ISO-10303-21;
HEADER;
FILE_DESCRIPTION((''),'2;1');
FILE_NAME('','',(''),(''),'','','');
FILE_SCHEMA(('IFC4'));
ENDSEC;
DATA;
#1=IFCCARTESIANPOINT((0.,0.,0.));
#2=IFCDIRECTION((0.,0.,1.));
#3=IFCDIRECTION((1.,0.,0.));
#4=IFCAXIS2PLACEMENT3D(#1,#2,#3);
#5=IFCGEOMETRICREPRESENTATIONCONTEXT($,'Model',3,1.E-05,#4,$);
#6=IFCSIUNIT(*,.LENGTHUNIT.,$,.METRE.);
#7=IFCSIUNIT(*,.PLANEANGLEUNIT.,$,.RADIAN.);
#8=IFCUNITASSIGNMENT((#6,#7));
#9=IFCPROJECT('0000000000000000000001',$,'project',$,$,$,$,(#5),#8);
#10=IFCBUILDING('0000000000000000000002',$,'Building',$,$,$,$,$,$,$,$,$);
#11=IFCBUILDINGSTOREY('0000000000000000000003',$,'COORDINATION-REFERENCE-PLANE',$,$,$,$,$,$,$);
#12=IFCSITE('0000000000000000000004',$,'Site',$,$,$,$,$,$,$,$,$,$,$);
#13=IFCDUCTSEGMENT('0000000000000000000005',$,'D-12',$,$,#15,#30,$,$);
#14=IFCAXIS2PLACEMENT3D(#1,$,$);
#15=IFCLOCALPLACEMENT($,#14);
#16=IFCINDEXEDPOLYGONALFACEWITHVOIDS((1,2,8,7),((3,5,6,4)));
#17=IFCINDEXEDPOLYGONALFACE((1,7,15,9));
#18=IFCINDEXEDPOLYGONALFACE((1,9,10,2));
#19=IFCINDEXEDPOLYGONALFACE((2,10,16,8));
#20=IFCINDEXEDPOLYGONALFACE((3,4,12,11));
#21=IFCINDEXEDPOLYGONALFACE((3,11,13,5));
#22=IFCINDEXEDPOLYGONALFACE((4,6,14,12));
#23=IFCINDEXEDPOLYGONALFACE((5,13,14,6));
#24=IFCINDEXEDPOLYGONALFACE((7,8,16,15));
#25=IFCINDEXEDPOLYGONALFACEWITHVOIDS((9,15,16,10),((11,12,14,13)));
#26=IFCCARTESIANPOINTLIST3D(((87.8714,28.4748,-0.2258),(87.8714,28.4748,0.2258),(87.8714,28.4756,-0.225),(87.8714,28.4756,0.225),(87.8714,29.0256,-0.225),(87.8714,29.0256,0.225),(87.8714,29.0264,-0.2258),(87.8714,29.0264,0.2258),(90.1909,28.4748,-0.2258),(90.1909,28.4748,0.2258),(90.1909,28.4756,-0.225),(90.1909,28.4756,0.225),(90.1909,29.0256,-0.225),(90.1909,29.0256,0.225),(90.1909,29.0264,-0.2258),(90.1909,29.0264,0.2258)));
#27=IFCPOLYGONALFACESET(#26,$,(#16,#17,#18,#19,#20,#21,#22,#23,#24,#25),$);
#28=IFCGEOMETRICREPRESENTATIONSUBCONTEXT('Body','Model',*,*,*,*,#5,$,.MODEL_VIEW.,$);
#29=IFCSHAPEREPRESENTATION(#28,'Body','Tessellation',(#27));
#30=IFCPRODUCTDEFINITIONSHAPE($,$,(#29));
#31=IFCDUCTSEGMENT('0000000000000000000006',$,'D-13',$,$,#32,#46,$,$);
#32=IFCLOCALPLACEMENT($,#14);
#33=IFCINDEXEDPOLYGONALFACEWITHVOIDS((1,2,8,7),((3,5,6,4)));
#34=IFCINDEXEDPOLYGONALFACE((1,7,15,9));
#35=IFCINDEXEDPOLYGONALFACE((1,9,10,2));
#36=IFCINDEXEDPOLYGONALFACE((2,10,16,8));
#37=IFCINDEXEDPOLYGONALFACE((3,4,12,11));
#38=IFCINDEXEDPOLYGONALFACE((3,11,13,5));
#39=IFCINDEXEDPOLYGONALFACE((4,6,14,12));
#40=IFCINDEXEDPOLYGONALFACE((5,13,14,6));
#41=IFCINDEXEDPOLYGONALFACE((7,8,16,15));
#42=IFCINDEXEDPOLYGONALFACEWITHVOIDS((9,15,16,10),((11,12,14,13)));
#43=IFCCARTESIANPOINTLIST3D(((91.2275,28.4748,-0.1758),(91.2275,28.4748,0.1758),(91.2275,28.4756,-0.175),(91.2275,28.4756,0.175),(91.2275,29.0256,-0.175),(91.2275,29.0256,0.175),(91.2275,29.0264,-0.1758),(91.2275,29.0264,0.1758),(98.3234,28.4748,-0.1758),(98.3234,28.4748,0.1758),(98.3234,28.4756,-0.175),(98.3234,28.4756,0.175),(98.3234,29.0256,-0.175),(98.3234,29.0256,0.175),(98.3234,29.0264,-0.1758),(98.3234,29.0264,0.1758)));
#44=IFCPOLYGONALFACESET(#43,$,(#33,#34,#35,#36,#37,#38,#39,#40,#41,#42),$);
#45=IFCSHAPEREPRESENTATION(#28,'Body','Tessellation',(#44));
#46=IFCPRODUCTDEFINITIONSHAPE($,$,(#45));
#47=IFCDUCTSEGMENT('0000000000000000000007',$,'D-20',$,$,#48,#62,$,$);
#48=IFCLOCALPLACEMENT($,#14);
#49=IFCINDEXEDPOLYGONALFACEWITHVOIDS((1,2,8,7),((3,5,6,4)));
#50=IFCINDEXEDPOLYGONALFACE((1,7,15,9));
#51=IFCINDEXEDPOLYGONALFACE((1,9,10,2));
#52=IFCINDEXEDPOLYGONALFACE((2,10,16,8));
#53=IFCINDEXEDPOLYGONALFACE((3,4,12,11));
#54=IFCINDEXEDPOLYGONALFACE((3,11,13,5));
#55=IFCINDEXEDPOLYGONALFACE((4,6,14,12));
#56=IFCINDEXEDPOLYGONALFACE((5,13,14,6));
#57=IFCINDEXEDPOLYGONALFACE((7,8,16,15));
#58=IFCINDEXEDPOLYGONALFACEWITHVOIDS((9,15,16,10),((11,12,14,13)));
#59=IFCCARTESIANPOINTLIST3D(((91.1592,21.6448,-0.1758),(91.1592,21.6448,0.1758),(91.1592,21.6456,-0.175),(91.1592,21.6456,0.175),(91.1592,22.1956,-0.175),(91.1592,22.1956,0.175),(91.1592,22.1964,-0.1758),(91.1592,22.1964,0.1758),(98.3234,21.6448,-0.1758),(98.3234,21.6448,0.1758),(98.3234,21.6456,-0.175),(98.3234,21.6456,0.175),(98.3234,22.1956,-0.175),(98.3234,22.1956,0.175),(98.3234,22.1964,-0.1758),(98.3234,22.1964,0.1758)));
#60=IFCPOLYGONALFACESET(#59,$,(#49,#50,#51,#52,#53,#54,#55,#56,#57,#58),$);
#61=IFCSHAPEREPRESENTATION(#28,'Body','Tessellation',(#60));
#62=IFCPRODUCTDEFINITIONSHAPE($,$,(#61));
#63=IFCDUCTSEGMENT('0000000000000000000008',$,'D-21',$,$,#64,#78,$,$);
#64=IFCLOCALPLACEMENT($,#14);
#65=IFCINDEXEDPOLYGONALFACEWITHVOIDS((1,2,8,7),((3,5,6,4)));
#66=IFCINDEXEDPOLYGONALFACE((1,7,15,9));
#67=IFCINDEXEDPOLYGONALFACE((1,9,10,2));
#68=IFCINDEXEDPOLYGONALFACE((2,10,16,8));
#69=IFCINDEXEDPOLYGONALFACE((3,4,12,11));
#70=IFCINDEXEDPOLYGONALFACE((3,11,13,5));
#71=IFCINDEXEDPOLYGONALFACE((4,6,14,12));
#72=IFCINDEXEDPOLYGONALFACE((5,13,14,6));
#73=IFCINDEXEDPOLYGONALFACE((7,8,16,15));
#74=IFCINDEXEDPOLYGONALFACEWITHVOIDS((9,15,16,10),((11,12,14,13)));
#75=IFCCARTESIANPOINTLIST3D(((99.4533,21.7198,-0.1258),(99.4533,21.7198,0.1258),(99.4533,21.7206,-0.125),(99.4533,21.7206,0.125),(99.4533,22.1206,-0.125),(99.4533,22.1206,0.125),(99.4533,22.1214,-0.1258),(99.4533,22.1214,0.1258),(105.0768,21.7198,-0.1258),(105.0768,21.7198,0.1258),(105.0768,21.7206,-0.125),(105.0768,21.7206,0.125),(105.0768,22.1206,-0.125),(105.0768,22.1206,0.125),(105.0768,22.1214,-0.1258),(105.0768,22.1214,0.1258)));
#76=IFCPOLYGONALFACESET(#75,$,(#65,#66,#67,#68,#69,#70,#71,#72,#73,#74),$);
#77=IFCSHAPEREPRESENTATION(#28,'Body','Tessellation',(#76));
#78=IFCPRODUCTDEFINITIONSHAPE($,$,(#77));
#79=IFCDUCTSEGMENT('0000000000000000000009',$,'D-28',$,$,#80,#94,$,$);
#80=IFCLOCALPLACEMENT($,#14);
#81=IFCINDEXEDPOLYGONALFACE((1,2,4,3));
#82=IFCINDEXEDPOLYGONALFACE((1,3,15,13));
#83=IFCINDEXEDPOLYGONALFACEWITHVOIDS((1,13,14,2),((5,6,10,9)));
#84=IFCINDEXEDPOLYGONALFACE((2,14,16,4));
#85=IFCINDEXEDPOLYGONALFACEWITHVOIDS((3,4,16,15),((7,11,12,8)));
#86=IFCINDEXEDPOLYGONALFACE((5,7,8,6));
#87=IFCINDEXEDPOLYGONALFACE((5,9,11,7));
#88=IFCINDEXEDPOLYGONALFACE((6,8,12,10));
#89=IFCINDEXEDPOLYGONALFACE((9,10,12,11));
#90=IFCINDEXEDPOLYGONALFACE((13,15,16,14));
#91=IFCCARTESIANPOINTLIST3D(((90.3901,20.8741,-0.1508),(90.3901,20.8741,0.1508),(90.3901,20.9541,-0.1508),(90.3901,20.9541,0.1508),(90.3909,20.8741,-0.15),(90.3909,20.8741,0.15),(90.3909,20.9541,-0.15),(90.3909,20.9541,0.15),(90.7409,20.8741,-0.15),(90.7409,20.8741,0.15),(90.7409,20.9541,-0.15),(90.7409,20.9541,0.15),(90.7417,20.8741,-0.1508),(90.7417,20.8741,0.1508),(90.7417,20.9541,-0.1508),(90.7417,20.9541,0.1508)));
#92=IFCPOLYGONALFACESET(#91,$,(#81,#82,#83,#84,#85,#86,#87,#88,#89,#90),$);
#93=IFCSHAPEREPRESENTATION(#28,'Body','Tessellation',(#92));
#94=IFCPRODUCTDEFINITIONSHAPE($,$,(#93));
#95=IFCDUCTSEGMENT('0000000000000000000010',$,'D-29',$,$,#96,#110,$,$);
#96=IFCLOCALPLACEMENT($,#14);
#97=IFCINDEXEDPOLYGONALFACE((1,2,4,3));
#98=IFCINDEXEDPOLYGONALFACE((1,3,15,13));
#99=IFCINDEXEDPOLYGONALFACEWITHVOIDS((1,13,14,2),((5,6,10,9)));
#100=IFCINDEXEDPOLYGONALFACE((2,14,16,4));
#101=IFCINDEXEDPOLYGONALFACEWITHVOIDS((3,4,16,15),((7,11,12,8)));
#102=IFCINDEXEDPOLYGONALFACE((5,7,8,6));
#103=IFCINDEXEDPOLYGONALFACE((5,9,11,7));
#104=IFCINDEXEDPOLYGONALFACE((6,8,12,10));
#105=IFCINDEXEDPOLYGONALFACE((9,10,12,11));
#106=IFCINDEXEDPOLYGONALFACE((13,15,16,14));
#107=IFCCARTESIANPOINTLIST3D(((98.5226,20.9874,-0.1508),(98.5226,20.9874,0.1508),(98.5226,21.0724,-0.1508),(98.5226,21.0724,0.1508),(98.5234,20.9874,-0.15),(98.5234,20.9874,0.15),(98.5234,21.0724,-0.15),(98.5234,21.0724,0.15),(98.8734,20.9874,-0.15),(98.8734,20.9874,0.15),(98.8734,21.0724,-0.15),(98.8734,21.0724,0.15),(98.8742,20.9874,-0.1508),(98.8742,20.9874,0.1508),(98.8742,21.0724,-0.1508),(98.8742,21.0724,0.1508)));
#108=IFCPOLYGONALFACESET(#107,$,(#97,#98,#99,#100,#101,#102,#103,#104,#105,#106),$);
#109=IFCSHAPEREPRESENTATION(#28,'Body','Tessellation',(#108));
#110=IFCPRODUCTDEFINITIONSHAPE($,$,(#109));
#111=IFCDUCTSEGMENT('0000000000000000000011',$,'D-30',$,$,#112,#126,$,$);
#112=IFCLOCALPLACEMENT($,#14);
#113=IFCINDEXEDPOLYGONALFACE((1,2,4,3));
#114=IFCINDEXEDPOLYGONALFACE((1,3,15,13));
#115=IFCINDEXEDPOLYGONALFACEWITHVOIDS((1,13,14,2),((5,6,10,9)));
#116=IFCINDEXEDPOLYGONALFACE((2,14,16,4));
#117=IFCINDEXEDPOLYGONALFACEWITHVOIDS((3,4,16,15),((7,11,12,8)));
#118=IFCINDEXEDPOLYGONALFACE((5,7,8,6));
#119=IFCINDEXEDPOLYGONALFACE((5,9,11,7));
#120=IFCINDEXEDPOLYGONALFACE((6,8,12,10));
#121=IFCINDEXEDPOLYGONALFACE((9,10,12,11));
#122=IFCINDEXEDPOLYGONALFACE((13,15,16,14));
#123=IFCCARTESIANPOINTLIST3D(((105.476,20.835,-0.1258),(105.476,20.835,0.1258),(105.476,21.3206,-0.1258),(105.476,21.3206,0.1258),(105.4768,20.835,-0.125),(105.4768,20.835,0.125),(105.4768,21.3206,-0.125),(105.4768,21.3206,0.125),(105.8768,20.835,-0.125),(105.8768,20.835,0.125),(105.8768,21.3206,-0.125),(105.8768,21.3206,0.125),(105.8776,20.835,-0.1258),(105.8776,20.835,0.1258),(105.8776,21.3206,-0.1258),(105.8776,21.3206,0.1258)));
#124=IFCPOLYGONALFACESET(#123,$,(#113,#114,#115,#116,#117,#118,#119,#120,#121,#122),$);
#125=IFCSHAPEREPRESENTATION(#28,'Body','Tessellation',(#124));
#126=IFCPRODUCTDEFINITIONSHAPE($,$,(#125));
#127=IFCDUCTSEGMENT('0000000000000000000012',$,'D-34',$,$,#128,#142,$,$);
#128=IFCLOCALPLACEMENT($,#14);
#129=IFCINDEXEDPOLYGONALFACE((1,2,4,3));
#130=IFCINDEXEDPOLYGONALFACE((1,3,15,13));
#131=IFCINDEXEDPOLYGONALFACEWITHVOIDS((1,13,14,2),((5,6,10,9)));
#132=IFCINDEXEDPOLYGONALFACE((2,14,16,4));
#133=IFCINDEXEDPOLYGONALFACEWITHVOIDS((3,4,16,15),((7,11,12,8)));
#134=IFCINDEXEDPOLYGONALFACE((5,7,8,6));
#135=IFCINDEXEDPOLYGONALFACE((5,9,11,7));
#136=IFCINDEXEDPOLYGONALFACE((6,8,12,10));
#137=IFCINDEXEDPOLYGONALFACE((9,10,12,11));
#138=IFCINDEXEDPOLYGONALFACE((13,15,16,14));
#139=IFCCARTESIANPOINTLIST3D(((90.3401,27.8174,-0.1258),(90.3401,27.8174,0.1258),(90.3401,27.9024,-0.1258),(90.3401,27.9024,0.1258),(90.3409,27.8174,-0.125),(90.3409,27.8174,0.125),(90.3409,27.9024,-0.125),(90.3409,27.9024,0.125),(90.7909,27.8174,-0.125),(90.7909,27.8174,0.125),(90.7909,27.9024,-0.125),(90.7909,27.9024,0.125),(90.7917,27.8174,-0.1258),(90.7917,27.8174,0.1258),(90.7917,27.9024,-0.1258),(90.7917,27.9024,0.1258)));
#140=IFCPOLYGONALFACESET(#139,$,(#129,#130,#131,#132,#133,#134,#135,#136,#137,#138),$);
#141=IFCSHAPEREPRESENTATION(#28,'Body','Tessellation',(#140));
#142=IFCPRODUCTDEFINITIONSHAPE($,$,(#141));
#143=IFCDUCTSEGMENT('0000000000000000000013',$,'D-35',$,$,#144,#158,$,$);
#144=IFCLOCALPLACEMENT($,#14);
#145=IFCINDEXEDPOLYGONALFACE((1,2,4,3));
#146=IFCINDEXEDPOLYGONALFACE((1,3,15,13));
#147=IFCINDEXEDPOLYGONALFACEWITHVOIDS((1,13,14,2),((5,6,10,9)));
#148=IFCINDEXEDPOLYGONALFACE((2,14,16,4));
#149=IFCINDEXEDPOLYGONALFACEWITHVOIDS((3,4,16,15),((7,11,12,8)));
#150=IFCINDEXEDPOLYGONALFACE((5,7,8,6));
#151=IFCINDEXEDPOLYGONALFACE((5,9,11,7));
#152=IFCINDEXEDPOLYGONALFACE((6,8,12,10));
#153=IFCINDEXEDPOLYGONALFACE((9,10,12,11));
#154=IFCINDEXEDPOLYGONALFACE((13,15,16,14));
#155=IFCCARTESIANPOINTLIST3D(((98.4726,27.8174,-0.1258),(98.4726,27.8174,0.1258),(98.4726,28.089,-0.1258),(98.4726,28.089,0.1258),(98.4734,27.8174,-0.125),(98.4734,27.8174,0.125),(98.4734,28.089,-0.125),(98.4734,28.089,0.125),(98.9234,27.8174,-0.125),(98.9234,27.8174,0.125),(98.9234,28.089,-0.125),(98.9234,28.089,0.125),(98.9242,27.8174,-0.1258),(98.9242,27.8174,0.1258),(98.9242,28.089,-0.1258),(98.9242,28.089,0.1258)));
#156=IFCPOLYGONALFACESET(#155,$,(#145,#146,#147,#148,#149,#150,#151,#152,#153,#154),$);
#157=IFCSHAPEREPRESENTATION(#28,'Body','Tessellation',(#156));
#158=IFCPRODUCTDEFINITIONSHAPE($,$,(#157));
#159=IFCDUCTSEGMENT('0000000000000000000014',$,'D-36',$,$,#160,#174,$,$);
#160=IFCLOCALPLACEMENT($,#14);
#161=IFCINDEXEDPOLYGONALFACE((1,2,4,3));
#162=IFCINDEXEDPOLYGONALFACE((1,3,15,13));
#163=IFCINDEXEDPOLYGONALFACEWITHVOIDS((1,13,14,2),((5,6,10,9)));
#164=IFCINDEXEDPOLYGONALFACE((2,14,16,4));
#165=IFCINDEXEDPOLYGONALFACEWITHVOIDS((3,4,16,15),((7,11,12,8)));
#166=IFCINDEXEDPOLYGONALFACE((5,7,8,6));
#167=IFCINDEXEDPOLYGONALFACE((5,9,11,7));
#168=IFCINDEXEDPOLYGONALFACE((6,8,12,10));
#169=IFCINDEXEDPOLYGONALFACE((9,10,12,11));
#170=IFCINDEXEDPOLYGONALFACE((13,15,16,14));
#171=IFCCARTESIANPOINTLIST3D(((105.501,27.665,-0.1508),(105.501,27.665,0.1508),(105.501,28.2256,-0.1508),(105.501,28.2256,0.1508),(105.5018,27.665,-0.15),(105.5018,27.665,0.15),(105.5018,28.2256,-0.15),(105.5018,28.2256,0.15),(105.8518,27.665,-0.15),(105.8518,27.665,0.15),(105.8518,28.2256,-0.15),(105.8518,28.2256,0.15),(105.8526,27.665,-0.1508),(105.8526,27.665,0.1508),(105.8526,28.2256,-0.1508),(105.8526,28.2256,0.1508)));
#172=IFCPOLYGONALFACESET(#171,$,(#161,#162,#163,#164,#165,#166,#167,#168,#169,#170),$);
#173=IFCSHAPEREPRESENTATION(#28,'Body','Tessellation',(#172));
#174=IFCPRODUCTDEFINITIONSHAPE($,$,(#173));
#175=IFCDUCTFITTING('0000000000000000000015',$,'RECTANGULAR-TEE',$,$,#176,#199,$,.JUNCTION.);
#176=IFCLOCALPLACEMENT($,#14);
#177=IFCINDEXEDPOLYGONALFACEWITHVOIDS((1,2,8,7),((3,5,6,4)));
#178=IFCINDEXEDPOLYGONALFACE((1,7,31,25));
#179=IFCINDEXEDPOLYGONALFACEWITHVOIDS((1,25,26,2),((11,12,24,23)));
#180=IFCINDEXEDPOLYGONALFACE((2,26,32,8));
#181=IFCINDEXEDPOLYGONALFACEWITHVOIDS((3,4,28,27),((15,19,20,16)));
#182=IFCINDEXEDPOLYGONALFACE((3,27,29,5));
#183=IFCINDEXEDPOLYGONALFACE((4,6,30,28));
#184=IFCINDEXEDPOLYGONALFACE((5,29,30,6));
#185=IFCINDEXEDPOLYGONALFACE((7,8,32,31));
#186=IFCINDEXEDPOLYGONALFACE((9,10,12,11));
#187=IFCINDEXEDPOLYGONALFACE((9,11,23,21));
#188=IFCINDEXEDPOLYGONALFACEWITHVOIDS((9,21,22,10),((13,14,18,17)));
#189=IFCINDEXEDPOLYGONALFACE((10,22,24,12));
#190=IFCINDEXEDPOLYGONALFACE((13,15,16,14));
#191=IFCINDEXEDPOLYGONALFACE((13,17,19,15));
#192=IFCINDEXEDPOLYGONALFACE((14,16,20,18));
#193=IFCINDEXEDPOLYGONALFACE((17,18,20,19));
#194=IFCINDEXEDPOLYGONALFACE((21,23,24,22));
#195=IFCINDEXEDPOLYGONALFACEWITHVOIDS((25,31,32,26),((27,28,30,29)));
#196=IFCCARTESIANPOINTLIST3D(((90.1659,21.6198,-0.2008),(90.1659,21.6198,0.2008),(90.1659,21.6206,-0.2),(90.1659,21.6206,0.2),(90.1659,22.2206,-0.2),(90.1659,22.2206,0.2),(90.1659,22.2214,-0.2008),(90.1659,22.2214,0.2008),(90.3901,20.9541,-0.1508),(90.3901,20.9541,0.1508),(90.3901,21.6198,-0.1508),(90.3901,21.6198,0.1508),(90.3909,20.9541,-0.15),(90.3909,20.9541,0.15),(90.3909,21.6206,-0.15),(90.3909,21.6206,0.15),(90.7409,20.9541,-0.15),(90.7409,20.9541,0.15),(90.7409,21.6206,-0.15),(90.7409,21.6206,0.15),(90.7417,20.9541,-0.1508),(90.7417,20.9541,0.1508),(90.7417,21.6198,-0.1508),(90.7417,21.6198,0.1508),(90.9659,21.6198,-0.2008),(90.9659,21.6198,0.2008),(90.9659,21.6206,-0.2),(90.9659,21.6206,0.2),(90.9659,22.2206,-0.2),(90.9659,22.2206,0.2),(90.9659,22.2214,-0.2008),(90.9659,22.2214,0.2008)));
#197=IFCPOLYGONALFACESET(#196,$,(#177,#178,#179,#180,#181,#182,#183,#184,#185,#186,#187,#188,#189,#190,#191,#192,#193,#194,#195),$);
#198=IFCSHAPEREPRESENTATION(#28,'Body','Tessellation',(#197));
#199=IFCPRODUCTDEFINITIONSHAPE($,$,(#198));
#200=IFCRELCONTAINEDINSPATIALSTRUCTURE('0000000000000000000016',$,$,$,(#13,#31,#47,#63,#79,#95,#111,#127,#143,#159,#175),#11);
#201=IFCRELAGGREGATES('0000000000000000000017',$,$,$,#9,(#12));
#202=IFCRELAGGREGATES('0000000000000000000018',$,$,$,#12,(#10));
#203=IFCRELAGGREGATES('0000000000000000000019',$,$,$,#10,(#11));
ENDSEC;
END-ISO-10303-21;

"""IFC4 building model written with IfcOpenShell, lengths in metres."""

from ifc_helpers import new_model, si_unit, frame, origin, origin_with_axes, place, context, subcontext, project, spatial, rectangle, hollow_rectangle, extrude, boolean, element, save


model = new_model("IFC4")

# Units and contexts
model_context = context("Model", 3, precision=1e-05, world=origin_with_axes())
body_context_1 = subcontext(model_context, "Body", "Model", "MODEL_VIEW")
ifc_project = project(units=[si_unit("LENGTHUNIT", "METRE"), si_unit("PLANEANGLEUNIT", "RADIAN")], contexts=[model_context])

# Site, building, storey
site = spatial("IfcSite", under=ifc_project, Name="Site")
building = spatial("IfcBuilding", under=site, Name="Building")
storey = spatial("IfcBuildingStorey", under=building, Name="COORDINATION-REFERENCE-PLANE")

# Duct segments
duct_segment_1_placement = place(None, frame((87.8714, 28.7506, 0.0), z_axis=(1.0, 0.0, 0.0), x_axis=(0.0, 1.0, 0.0)))
element("IfcDuctSegment", 1, at=duct_segment_1_placement, inside=storey, Name="D-12", context=body_context_1, shape_type="SweptSolid", body=[
    extrude(hollow_rectangle(XDim=0.5516, YDim=0.4516, WallThickness=0.0008), origin(), (0.0, 0.0, 1.0), 2.3195),
])
duct_segment_2_placement = place(None, frame((91.2275, 28.7506, 0.0), z_axis=(1.0, 0.0, 0.0), x_axis=(0.0, 1.0, 0.0)))
element("IfcDuctSegment", 2, at=duct_segment_2_placement, inside=storey, Name="D-13", context=body_context_1, shape_type="SweptSolid", body=[
    extrude(hollow_rectangle(XDim=0.5516, YDim=0.3516, WallThickness=0.0008), origin(), (0.0, 0.0, 1.0), 7.0959),
])
duct_segment_3_placement = place(None, frame((91.1592, 21.9206, 0.0), z_axis=(1.0, 0.0, 0.0), x_axis=(0.0, 1.0, 0.0)))
element("IfcDuctSegment", 3, at=duct_segment_3_placement, inside=storey, Name="D-20", context=body_context_1, shape_type="SweptSolid", body=[
    extrude(hollow_rectangle(XDim=0.5516, YDim=0.3516, WallThickness=0.0008), origin(), (0.0, 0.0, 1.0), 7.1642),
])
duct_segment_4_placement = place(None, frame((99.4533, 21.9206, 0.0), z_axis=(1.0, 0.0, 0.0), x_axis=(0.0, 1.0, 0.0)))
element("IfcDuctSegment", 4, at=duct_segment_4_placement, inside=storey, Name="D-21", context=body_context_1, shape_type="SweptSolid", body=[
    extrude(hollow_rectangle(XDim=0.4016, YDim=0.2516, WallThickness=0.0008), origin(), (0.0, 0.0, 1.0), 5.6234),
])
duct_segment_5_placement = place(None, frame((90.5659, 20.8741, 0.0), z_axis=(0.0, 1.0, 0.0), x_axis=(1.0, 0.0, 0.0)))
element("IfcDuctSegment", 5, at=duct_segment_5_placement, inside=storey, Name="D-28", context=body_context_1, shape_type="SweptSolid", body=[
    extrude(hollow_rectangle(XDim=0.3516, YDim=0.3016, WallThickness=0.0008), origin(), (0.0, 0.0, 1.0), 0.08),
])
duct_segment_6_placement = place(None, frame((98.6984, 20.9874, 0.0), z_axis=(0.0, 1.0, 0.0), x_axis=(1.0, 0.0, 0.0)))
element("IfcDuctSegment", 6, at=duct_segment_6_placement, inside=storey, Name="D-29", context=body_context_1, shape_type="SweptSolid", body=[
    extrude(hollow_rectangle(XDim=0.3516, YDim=0.3016, WallThickness=0.0008), origin(), (0.0, 0.0, 1.0), 0.085),
])
duct_segment_7_placement = place(None, frame((105.6768, 20.835, 0.0), z_axis=(0.0, 1.0, 0.0), x_axis=(1.0, 0.0, 0.0)))
element("IfcDuctSegment", 7, at=duct_segment_7_placement, inside=storey, Name="D-30", context=body_context_1, shape_type="SweptSolid", body=[
    extrude(hollow_rectangle(XDim=0.4016, YDim=0.2516, WallThickness=0.0008), origin(), (0.0, 0.0, 1.0), 0.4856),
])
duct_segment_8_placement = place(None, frame((90.5659, 27.8174, 0.0), z_axis=(0.0, 1.0, 0.0), x_axis=(1.0, 0.0, 0.0)))
element("IfcDuctSegment", 8, at=duct_segment_8_placement, inside=storey, Name="D-34", context=body_context_1, shape_type="SweptSolid", body=[
    extrude(hollow_rectangle(XDim=0.4516, YDim=0.2516, WallThickness=0.0008), origin(), (0.0, 0.0, 1.0), 0.085),
])
duct_segment_9_placement = place(None, frame((98.6984, 27.8174, 0.0), z_axis=(0.0, 1.0, 0.0), x_axis=(1.0, 0.0, 0.0)))
element("IfcDuctSegment", 9, at=duct_segment_9_placement, inside=storey, Name="D-35", context=body_context_1, shape_type="SweptSolid", body=[
    extrude(hollow_rectangle(XDim=0.4516, YDim=0.2516, WallThickness=0.0008), origin(), (0.0, 0.0, 1.0), 0.2716),
])
duct_segment_10_placement = place(None, frame((105.6768, 27.665, 0.0), z_axis=(0.0, 1.0, 0.0), x_axis=(1.0, 0.0, 0.0)))
element("IfcDuctSegment", 10, at=duct_segment_10_placement, inside=storey, Name="D-36", context=body_context_1, shape_type="SweptSolid", body=[
    extrude(hollow_rectangle(XDim=0.3516, YDim=0.3016, WallThickness=0.0008), origin(), (0.0, 0.0, 1.0), 0.5606),
])

# Duct fitting
duct_fitting_1_placement = place(None, frame((90.5659, 21.9206, 0.0), z_axis=(1.0, 0.0, 0.0), x_axis=(0.0, -1.0, 0.0)))
solid_1 = boolean("UNION", extrude(rectangle(XDim=0.6, YDim=0.4), frame((0.0, 0.0, -0.4), z_axis=(0.0, 0.0, 1.0), x_axis=(1.0, 0.0, 0.0)), (0.0, 0.0, 1.0), 0.8), extrude(rectangle(XDim=0.35, YDim=0.3), frame((0.0, 0.0, 0.0), z_axis=(1.0, 0.0, 0.0), x_axis=(0.0, 0.0, -1.0)), (0.0, 0.0, 1.0), 0.9665))
element("IfcDuctFitting", 11, at=duct_fitting_1_placement, inside=storey, Name="RECTANGULAR-TEE", PredefinedType="JUNCTION", context=body_context_1, shape_type="CSG", body=[
    boolean("DIFFERENCE", boolean("UNION", extrude(rectangle(XDim=0.6016, YDim=0.4016), frame((0.0, 0.0, -0.4), z_axis=(0.0, 0.0, 1.0), x_axis=(1.0, 0.0, 0.0)), (0.0, 0.0, 1.0), 0.8), extrude(rectangle(XDim=0.3516, YDim=0.3016), frame((0.0, 0.0, 0.0), z_axis=(1.0, 0.0, 0.0), x_axis=(0.0, 0.0, -1.0)), (0.0, 0.0, 1.0), 0.9665)), solid_1),
])

save(model, "model.ifc")
